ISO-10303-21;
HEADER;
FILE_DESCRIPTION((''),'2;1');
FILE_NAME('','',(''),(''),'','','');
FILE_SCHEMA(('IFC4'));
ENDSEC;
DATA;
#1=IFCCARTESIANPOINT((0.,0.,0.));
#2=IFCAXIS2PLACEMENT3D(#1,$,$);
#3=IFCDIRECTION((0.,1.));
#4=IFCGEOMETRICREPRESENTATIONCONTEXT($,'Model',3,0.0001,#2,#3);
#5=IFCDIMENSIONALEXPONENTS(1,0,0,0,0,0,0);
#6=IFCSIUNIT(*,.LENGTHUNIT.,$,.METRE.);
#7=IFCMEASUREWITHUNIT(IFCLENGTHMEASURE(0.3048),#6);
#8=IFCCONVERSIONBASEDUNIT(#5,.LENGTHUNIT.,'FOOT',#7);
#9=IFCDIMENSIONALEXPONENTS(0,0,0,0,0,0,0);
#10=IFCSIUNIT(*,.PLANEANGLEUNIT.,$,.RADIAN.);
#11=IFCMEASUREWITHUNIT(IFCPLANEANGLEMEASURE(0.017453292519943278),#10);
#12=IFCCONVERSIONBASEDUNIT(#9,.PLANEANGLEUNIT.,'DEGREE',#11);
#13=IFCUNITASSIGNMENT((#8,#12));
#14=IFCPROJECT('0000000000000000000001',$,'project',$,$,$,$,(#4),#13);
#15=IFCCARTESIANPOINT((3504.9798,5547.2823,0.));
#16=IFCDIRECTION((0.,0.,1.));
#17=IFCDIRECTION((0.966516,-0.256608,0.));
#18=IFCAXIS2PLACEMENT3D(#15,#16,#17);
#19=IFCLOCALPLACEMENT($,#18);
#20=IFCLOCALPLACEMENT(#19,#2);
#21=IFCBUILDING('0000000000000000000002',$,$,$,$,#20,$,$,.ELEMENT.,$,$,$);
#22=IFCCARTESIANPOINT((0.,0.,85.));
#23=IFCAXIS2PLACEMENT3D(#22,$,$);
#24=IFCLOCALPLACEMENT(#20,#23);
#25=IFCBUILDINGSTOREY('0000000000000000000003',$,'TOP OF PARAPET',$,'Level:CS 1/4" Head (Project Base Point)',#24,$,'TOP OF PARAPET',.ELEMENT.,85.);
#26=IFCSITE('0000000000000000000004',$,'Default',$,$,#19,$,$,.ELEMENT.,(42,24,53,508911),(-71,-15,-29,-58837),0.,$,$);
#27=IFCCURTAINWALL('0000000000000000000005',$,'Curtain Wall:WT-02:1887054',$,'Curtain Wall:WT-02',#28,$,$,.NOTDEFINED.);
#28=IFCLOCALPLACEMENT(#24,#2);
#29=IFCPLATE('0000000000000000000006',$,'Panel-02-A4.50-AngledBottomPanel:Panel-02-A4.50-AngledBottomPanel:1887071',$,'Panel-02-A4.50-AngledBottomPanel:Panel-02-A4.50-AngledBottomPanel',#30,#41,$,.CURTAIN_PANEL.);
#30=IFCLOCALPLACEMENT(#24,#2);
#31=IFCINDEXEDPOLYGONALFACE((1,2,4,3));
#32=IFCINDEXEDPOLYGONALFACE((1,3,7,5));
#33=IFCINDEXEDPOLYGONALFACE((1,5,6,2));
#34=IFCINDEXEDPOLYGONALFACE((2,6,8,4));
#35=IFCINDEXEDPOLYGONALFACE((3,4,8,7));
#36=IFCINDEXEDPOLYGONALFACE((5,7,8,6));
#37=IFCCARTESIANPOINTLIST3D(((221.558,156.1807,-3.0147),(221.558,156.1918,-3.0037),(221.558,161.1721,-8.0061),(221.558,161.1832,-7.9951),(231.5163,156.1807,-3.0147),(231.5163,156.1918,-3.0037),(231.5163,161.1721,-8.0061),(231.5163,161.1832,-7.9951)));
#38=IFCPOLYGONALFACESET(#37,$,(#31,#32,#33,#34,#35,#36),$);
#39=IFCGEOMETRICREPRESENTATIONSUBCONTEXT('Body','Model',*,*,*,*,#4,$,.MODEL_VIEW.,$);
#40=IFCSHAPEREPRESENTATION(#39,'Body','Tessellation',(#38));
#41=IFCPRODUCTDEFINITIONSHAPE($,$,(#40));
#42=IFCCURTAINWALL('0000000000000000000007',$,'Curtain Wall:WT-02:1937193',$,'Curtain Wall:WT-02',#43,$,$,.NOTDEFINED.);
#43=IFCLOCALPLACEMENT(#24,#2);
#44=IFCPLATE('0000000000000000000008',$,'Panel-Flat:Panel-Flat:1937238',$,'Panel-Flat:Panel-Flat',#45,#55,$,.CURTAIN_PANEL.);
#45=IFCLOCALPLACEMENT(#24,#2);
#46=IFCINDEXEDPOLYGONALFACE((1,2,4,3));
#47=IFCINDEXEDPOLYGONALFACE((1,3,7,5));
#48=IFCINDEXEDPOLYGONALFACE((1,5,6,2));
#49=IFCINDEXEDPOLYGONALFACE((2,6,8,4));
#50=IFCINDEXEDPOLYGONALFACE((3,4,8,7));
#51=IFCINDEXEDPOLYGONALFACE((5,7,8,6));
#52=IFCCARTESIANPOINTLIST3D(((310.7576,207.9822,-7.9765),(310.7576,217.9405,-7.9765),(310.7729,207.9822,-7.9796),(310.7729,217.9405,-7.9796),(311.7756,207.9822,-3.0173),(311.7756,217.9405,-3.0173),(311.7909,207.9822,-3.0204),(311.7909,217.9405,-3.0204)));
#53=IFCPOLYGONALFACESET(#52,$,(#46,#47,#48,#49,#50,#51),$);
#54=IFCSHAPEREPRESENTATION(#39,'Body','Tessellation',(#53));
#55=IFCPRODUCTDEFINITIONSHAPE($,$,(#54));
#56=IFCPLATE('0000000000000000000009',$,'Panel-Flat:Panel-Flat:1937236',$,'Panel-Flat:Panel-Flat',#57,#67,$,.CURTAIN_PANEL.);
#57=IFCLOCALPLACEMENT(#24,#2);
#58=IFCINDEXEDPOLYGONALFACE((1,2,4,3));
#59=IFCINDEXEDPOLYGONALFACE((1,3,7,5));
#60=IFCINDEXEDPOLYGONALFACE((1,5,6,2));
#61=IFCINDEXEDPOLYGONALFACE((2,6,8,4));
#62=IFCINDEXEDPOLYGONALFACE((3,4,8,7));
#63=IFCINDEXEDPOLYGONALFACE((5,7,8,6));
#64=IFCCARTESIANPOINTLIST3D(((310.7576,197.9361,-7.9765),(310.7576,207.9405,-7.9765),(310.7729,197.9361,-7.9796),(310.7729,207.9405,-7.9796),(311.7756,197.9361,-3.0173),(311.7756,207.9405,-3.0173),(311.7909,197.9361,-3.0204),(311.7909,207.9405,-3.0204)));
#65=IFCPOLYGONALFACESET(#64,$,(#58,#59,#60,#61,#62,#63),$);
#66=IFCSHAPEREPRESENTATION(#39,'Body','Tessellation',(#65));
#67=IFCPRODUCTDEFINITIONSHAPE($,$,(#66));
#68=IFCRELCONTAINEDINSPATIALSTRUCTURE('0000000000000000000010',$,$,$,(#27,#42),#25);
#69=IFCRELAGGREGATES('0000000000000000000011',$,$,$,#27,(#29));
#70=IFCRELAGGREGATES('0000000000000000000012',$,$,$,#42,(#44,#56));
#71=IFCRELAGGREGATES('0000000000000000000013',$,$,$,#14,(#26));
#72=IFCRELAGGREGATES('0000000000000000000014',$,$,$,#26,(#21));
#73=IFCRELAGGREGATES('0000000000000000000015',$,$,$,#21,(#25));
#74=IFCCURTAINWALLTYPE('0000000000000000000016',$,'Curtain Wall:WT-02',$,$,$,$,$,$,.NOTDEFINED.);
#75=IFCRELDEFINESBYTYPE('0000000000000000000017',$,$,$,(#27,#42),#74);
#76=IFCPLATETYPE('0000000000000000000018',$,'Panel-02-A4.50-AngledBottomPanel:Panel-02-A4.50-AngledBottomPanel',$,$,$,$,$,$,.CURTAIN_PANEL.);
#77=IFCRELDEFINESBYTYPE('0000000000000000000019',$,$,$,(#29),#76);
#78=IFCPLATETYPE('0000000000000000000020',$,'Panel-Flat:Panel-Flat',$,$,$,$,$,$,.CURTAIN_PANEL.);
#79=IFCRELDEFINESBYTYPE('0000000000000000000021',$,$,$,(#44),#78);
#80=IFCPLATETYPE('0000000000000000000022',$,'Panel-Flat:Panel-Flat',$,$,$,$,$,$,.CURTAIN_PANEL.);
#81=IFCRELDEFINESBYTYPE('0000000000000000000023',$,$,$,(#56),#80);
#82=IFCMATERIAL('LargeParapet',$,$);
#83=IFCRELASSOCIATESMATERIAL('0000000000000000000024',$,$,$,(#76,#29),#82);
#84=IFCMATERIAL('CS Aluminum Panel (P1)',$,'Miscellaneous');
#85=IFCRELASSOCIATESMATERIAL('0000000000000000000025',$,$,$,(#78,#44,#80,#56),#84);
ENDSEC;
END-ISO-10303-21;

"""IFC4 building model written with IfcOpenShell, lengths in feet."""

from ifc_helpers import new_model, entity, si_unit, converted_unit, direction, frame, origin, place, context, subcontext, project, spatial, indexed_curve, outline, extrude, source, transform, mapped, material, type_object, type_shapes, element, aggregate, save


model = new_model("IFC4")

# Units and contexts
model_context = context("Model", 3, precision=0.0001, world=origin(), true_north=direction((0.0, 1.0)))
body_context = subcontext(model_context, "Body", "Model", "MODEL_VIEW")
ifc_project = project(units=[converted_unit("LENGTHUNIT", "FOOT", entity("IfcLengthMeasure", 0.3048), si_unit("LENGTHUNIT", "METRE"), dimensions=[1, 0, 0, 0, 0, 0, 0]), converted_unit("PLANEANGLEUNIT", "DEGREE", entity("IfcPlaneAngleMeasure", 0.017453292519943278), si_unit("PLANEANGLEUNIT", "RADIAN"), dimensions=[0, 0, 0, 0, 0, 0, 0])], contexts=[model_context])

# Site, building, storey
site_placement = place(None, frame((3504.9798, 5547.2823, 0.0), z_axis=(0.0, 0.0, 1.0), x_axis=(0.966516, -0.256608, 0.0)))
site = spatial("IfcSite", under=ifc_project, at=site_placement, Name="Default", CompositionType="ELEMENT", RefLatitude=(42, 24, 53, 508911), RefLongitude=(-71, -15, -29, -58837), RefElevation=0.0)
building_placement = place(site_placement, origin())
building = spatial("IfcBuilding", under=site, at=building_placement, CompositionType="ELEMENT")
storey_placement = place(building_placement, frame((0.0, 0.0, 85.0)))
storey = spatial("IfcBuildingStorey", under=building, at=storey_placement, Name="TOP OF PARAPET", ObjectType="Level:CS 1/4\" Head (Project Base Point)", LongName="TOP OF PARAPET", CompositionType="ELEMENT", Elevation=85.0)

# Shared definitions
curtain_wall_type_1 = type_object("IfcCurtainWallType", Name="Curtain Wall:WT-02", PredefinedType="NOTDEFINED")
ifc_material_1 = material(Name="LargeParapet")

# Curtain walls, plates
curtain_wall_1_placement = place(storey_placement, frame((0.0, 0.0, -85.0)))
curtain_wall_1 = element("IfcCurtainWall", 1, at=curtain_wall_1_placement, inside=storey, type_object=curtain_wall_type_1, Name="Curtain Wall:WT-02:1887054", ObjectType="Curtain Wall:WT-02", PredefinedType="NOTDEFINED")
plate_type_1 = type_object("IfcPlateType", Name="Panel-02-A4.50-AngledBottomPanel:Panel-02-A4.50-AngledBottomPanel", PredefinedType="CURTAIN_PANEL", material=ifc_material_1)
shared_shape_1 = source(origin(), body_context, "Body", "SweptSolid", [
    extrude(outline(indexed_curve([(-0.0078, -4.9792), (0.0078, -4.9792), (0.0078, 4.9792), (-0.0078, 4.9792), (-0.0078, -4.9792)], self_intersect=False)), frame((4.9792, 0.0078, 0.0), z_axis=(0.0, 0.0, 1.0), x_axis=(0.0, -1.0, 0.0)), (0.0, 0.0, 1.0), 7.0589),
])
type_shapes(plate_type_1, [shared_shape_1])
plate_1_placement = place(curtain_wall_1_placement, frame((231.5163, 161.1832, 77.0049), z_axis=(0.0, -0.707107, 0.707107), x_axis=(-1.0, 0.0, 0.0)))
plate_1 = element("IfcPlate", 2, at=plate_1_placement, type_object=plate_type_1, material=ifc_material_1, Name="Panel-02-A4.50-AngledBottomPanel:Panel-02-A4.50-AngledBottomPanel:1887071", ObjectType="Panel-02-A4.50-AngledBottomPanel:Panel-02-A4.50-AngledBottomPanel", PredefinedType="CURTAIN_PANEL", context=body_context, shape_type="MappedRepresentation", body=[
    mapped(shared_shape_1, transform((0.0, 0.0, 0.0), scale=1.0)),
])
aggregate(curtain_wall_1, [plate_1])
curtain_wall_2_placement = place(storey_placement, frame((0.0, 0.0, -85.0)))
curtain_wall_2 = element("IfcCurtainWall", 3, at=curtain_wall_2_placement, inside=storey, type_object=curtain_wall_type_1, Name="Curtain Wall:WT-02:1937193", ObjectType="Curtain Wall:WT-02", PredefinedType="NOTDEFINED")
ifc_material_2 = material(Name="CS Aluminum Panel (P1)", Category="Miscellaneous")
plate_type_2 = type_object("IfcPlateType", Name="Panel-Flat:Panel-Flat", PredefinedType="CURTAIN_PANEL", material=ifc_material_2)
shared_shape_2 = source(origin(), body_context, "Body", "SweptSolid", [
    extrude(outline(indexed_curve([(-0.0078, -4.9792), (0.0078, -4.9792), (0.0078, 4.9792), (-0.0078, 4.9792), (-0.0078, -4.9792)], self_intersect=False)), frame((4.9792, 0.0078, 0.0), z_axis=(0.0, 0.0, 1.0), x_axis=(0.0, -1.0, 0.0)), (0.0, 0.0, 1.0), 5.0626),
])
type_shapes(plate_type_2, [shared_shape_2])
plate_2_placement = place(curtain_wall_2_placement, frame((310.7576, 217.9405, 77.0235), z_axis=(0.201078, 0.0, 0.979575), x_axis=(0.0, -1.0, 0.0)))
plate_2 = element("IfcPlate", 4, at=plate_2_placement, type_object=plate_type_2, material=ifc_material_2, Name="Panel-Flat:Panel-Flat:1937238", ObjectType="Panel-Flat:Panel-Flat", PredefinedType="CURTAIN_PANEL", context=body_context, shape_type="MappedRepresentation", body=[
    mapped(shared_shape_2, transform((0.0, 0.0, 0.0), scale=1.0)),
])
plate_type_3 = type_object("IfcPlateType", Name="Panel-Flat:Panel-Flat", PredefinedType="CURTAIN_PANEL", material=ifc_material_2)
shared_shape_3 = source(origin(), body_context, "Body", "SweptSolid", [
    extrude(outline(indexed_curve([(-0.0078, -5.0022), (0.0078, -5.0022), (0.0078, 5.0022), (-0.0078, 5.0022), (-0.0078, -5.0022)], self_intersect=False)), frame((5.0022, 0.0078, 0.0), z_axis=(0.0, 0.0, 1.0), x_axis=(0.0, -1.0, 0.0)), (0.0, 0.0, 1.0), 5.0626),
])
type_shapes(plate_type_3, [shared_shape_3])
plate_3_placement = place(curtain_wall_2_placement, frame((310.7576, 207.9405, 77.0235), z_axis=(0.201078, 0.0, 0.979575), x_axis=(0.0, -1.0, 0.0)))
plate_3 = element("IfcPlate", 5, at=plate_3_placement, type_object=plate_type_3, material=ifc_material_2, Name="Panel-Flat:Panel-Flat:1937236", ObjectType="Panel-Flat:Panel-Flat", PredefinedType="CURTAIN_PANEL", context=body_context, shape_type="MappedRepresentation", body=[
    mapped(shared_shape_3, transform((0.0, 0.0, 0.0), scale=1.0)),
])
aggregate(curtain_wall_2, [plate_2, plate_3])

save(model, "model.ifc")
